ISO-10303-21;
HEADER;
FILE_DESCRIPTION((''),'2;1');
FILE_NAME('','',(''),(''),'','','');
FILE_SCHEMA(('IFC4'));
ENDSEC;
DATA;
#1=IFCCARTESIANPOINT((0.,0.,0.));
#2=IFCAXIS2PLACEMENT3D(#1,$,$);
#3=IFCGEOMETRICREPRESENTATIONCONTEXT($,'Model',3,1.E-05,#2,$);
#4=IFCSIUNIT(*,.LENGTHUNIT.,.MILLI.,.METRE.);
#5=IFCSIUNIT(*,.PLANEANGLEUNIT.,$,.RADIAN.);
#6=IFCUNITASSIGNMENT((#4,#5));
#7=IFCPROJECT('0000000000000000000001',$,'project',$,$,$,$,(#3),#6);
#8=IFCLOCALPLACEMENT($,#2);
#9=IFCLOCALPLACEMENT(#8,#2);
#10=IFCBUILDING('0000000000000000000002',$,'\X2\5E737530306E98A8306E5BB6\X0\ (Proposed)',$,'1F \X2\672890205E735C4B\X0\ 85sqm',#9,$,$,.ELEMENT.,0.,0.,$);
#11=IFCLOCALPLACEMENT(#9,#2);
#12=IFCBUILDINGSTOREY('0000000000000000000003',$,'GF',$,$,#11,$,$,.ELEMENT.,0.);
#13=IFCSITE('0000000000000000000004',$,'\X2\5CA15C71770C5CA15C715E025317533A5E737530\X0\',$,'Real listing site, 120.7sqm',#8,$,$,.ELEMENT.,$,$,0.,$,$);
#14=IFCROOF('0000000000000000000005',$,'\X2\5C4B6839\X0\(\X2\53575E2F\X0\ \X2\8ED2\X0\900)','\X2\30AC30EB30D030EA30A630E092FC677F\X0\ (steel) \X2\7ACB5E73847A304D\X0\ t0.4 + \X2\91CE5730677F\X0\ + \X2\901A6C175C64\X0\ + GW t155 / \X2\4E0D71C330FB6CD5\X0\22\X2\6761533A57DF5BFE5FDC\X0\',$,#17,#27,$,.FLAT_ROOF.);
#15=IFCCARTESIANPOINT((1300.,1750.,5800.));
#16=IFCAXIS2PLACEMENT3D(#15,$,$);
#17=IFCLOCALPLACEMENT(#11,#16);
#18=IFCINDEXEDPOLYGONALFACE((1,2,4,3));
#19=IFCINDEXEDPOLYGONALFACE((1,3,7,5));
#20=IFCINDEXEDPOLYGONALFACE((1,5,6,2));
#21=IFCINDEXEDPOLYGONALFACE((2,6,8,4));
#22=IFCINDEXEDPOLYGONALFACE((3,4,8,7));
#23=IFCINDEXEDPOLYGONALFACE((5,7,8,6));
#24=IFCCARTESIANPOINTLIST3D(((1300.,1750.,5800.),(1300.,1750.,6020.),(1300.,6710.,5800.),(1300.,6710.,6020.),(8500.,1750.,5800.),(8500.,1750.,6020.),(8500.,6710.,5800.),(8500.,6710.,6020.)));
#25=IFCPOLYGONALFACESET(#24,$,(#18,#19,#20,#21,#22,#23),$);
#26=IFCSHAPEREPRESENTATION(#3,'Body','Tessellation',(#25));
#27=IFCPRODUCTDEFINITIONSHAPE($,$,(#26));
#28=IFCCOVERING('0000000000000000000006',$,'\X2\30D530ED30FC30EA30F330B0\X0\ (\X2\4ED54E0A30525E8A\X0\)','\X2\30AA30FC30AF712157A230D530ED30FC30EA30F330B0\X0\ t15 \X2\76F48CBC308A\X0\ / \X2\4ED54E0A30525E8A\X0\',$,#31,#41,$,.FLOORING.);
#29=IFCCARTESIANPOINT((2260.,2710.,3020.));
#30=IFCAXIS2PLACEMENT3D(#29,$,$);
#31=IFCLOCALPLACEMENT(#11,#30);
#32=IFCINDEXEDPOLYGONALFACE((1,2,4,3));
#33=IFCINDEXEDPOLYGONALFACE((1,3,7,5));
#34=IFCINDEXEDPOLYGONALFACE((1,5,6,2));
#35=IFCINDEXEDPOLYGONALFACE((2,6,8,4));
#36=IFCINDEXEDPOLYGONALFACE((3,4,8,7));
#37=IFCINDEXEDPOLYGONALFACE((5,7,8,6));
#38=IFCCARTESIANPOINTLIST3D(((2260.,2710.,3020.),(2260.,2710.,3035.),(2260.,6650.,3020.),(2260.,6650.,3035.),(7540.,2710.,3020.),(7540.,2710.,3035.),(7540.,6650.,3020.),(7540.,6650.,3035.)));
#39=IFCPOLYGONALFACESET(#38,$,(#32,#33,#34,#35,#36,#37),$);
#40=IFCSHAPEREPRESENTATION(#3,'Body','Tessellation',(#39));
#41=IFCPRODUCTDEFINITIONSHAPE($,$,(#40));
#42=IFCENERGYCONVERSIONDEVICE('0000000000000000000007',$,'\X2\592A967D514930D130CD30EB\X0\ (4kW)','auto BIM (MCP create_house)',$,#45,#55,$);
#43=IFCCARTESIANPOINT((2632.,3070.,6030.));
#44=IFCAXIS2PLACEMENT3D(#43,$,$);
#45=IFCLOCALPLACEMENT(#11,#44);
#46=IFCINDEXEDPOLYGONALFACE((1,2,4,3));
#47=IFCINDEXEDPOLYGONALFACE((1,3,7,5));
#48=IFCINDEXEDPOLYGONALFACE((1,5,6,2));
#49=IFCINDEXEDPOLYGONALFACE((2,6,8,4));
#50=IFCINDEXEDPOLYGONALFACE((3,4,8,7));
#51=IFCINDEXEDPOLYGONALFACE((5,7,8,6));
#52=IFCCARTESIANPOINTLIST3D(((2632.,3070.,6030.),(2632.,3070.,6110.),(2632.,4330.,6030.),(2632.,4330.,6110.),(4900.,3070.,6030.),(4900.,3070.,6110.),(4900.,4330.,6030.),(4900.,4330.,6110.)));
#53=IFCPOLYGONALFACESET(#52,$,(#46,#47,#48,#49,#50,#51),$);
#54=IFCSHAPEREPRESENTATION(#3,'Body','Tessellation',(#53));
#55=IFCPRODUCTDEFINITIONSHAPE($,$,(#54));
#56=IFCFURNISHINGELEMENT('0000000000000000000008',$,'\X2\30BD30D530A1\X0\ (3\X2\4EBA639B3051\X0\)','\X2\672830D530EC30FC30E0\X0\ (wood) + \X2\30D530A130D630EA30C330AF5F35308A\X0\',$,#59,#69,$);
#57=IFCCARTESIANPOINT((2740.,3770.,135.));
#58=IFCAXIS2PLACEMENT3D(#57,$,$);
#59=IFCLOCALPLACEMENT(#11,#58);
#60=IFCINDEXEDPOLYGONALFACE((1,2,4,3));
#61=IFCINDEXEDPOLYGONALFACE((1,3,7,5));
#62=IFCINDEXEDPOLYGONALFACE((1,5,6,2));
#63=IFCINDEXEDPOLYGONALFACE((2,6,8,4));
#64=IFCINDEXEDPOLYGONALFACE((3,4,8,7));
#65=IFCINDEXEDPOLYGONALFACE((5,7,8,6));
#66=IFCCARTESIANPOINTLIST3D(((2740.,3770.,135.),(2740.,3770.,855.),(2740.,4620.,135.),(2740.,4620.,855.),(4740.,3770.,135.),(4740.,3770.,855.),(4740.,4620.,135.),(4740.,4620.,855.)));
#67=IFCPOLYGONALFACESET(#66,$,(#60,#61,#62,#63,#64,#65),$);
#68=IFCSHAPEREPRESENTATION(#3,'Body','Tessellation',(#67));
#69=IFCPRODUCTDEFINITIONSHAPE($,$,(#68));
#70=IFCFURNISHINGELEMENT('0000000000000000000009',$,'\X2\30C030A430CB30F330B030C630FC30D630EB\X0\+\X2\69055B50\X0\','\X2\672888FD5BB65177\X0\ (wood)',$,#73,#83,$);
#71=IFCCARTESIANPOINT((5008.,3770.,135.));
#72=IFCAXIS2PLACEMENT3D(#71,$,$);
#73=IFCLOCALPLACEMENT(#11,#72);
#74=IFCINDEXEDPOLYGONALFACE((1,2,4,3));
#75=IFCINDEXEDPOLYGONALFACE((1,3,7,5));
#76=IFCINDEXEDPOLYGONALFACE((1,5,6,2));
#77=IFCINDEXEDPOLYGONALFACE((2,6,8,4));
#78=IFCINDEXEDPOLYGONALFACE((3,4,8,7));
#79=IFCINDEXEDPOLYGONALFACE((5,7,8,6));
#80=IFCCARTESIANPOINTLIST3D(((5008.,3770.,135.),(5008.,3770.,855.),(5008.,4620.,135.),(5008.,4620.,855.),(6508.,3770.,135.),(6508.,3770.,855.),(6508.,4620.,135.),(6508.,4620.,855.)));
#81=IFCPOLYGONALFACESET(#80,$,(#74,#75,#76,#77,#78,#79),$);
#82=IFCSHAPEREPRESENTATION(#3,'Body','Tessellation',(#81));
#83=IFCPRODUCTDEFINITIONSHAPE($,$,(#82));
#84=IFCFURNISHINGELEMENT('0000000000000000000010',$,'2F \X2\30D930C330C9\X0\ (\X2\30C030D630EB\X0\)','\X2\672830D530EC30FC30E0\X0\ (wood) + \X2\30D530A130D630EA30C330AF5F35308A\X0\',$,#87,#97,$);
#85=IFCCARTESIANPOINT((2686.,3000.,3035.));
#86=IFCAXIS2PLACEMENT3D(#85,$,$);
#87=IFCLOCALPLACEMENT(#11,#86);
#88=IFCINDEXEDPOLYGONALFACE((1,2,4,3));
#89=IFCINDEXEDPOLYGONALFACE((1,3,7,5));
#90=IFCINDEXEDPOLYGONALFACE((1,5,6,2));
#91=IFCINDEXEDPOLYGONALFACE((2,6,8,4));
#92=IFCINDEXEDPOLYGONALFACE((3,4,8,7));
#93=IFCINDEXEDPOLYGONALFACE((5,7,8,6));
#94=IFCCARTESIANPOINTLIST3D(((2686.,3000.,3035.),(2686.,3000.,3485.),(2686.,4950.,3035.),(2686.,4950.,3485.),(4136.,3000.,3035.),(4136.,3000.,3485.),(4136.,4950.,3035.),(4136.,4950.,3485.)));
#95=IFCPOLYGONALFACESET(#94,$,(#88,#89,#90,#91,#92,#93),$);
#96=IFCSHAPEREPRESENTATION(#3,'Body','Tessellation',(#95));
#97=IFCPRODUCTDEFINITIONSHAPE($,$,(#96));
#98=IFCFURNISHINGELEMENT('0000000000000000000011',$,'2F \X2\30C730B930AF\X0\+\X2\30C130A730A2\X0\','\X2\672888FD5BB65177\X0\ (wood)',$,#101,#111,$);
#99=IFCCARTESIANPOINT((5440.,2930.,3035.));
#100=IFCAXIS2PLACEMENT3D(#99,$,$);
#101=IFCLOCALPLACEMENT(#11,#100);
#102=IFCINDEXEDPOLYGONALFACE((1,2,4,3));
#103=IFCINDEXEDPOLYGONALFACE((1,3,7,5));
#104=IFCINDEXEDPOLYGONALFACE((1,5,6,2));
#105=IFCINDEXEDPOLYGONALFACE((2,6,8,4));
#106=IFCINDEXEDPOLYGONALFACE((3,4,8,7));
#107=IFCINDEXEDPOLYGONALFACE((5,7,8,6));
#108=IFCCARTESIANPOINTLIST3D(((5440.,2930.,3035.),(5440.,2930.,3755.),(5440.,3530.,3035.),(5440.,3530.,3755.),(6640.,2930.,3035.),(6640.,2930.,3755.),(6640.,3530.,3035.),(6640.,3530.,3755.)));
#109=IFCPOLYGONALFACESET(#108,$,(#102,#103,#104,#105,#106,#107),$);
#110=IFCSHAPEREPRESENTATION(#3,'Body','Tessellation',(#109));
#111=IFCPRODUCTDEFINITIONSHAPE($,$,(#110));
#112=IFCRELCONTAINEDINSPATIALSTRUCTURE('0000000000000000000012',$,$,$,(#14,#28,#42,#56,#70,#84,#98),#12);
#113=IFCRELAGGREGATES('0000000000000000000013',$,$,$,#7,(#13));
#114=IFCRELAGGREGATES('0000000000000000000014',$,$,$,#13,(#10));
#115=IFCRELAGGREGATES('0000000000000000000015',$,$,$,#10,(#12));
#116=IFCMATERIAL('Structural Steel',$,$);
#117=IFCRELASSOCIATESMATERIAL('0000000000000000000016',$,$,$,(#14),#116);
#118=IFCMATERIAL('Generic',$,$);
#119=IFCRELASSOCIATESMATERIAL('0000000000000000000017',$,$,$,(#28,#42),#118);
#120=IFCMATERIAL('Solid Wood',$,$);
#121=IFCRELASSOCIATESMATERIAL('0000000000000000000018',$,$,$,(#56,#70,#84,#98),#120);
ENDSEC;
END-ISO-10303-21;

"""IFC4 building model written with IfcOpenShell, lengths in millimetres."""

from ifc_helpers import new_model, si_unit, frame, frame_2d, origin, place, context, project, spatial, rectangle, extrude, material, element, save


model = new_model("IFC4")

# Units and contexts
model_context = context("Model", 3, precision=1e-05, world=origin())
ifc_project = project(units=[si_unit("LENGTHUNIT", "METRE", prefix="MILLI"), si_unit("PLANEANGLEUNIT", "RADIAN")], contexts=[model_context])

# Site, building, storey
site_placement = place(None, origin())
site = spatial("IfcSite", under=ifc_project, at=site_placement, Name="岡山県岡山市北区平田", ObjectType="Real listing site, 120.7sqm", CompositionType="ELEMENT", RefElevation=0.0)
building_placement = place(site_placement, origin())
building = spatial("IfcBuilding", under=site, at=building_placement, Name="平田の風の家 (Proposed)", ObjectType="1F 木造平屋 85sqm", CompositionType="ELEMENT", ElevationOfRefHeight=0.0, ElevationOfTerrain=0.0)
storey_placement = place(building_placement, origin())
storey = spatial("IfcBuildingStorey", under=building, at=storey_placement, Name="GF", CompositionType="ELEMENT", Elevation=0.0)

# Shared definitions
ifc_material_1 = material(Name="Solid Wood")

# Shared definitions
ifc_material_2 = material(Name="Generic")

# Roof
ifc_material_3 = material(Name="Structural Steel")
for number, where, name in (
    (1, (1300.0, 1750.0, 5800.0), "屋根(南帯 軒900)"),
):
    element("IfcRoof", number, at=place(storey_placement, frame(where)), inside=storey, material=ifc_material_3, Name=name, Description="ガルバリウム鋼板 (steel) 立平葺き t0.4 + 野地板 + 通気層 + GW t155 / 不燃・法22条区域対応", PredefinedType="FLAT_ROOF", context=model_context, shape_type="SweptSolid", body=[
        extrude(rectangle(XDim=7200.0, YDim=4960.0, at=frame_2d((3600.0, 2480.0))), frame((1300.0, 1750.0, 5800.0)), (0.0, 0.0, 1.0), 220.0),
    ])

# Covering
covering_placement = place(storey_placement, frame((2260.0, 2710.0, 3020.0)))
element("IfcCovering", 2, at=covering_placement, inside=storey, material=ifc_material_2, Name="フローリング (仕上げ床)", Description="オーク無垢フローリング t15 直貼り / 仕上げ床", PredefinedType="FLOORING", context=model_context, shape_type="SweptSolid", body=[
    extrude(rectangle(XDim=5280.0, YDim=3940.0, at=frame_2d((2640.0, 1970.0))), frame((2260.0, 2710.0, 3020.0)), (0.0, 0.0, 1.0), 15.0),
])

# Energy conversion device
energy_conversion_device_placement = place(storey_placement, frame((2632.0, 3070.0, 6030.0)))
element("IfcEnergyConversionDevice", 3, at=energy_conversion_device_placement, inside=storey, material=ifc_material_2, Name="太陽光パネル (4kW)", Description="auto BIM (MCP create_house)", context=model_context, shape_type="SweptSolid", body=[
    extrude(rectangle(XDim=2268.0, YDim=1260.0, at=frame_2d((1134.0, 630.0))), frame((2632.0, 3070.0, 6030.0)), (0.0, 0.0, 1.0), 80.0),
])

# Furnishing elements
furnishing_1_placement = place(storey_placement, frame((2740.0, 3770.0, 135.0)))
element("IfcFurnishingElement", 4, at=furnishing_1_placement, inside=storey, material=ifc_material_1, Name="ソファ (3人掛け)", Description="木フレーム (wood) + ファブリック張り", context=model_context, shape_type="SweptSolid", body=[
    extrude(rectangle(XDim=2000.0, YDim=850.0, at=frame_2d((1000.0, 425.0))), frame((2740.0, 3770.0, 135.0)), (0.0, 0.0, 1.0), 720.0),
])
furnishing_2_placement = place(storey_placement, frame((5008.0, 3770.0, 135.0)))
element("IfcFurnishingElement", 5, at=furnishing_2_placement, inside=storey, material=ifc_material_1, Name="ダイニングテーブル+椅子", Description="木製家具 (wood)", context=model_context, shape_type="SweptSolid", body=[
    extrude(rectangle(XDim=1500.0, YDim=850.0, at=frame_2d((750.0, 425.0))), frame((5008.0, 3770.0, 135.0)), (0.0, 0.0, 1.0), 720.0),
])
furnishing_3_placement = place(storey_placement, frame((2686.0, 3000.0, 3035.0)))
element("IfcFurnishingElement", 6, at=furnishing_3_placement, inside=storey, material=ifc_material_1, Name="2F ベッド (ダブル)", Description="木フレーム (wood) + ファブリック張り", context=model_context, shape_type="SweptSolid", body=[
    extrude(rectangle(XDim=1450.0, YDim=1950.0, at=frame_2d((725.0, 975.0))), frame((2686.0, 3000.0, 3035.0)), (0.0, 0.0, 1.0), 450.0),
])
furnishing_4_placement = place(storey_placement, frame((5440.0, 2930.0, 3035.0)))
element("IfcFurnishingElement", 7, at=furnishing_4_placement, inside=storey, material=ifc_material_1, Name="2F デスク+チェア", Description="木製家具 (wood)", context=model_context, shape_type="SweptSolid", body=[
    extrude(rectangle(XDim=1200.0, YDim=600.0, at=frame_2d((600.0, 300.0))), frame((5440.0, 2930.0, 3035.0)), (0.0, 0.0, 1.0), 720.0),
])

save(model, "model.ifc")
